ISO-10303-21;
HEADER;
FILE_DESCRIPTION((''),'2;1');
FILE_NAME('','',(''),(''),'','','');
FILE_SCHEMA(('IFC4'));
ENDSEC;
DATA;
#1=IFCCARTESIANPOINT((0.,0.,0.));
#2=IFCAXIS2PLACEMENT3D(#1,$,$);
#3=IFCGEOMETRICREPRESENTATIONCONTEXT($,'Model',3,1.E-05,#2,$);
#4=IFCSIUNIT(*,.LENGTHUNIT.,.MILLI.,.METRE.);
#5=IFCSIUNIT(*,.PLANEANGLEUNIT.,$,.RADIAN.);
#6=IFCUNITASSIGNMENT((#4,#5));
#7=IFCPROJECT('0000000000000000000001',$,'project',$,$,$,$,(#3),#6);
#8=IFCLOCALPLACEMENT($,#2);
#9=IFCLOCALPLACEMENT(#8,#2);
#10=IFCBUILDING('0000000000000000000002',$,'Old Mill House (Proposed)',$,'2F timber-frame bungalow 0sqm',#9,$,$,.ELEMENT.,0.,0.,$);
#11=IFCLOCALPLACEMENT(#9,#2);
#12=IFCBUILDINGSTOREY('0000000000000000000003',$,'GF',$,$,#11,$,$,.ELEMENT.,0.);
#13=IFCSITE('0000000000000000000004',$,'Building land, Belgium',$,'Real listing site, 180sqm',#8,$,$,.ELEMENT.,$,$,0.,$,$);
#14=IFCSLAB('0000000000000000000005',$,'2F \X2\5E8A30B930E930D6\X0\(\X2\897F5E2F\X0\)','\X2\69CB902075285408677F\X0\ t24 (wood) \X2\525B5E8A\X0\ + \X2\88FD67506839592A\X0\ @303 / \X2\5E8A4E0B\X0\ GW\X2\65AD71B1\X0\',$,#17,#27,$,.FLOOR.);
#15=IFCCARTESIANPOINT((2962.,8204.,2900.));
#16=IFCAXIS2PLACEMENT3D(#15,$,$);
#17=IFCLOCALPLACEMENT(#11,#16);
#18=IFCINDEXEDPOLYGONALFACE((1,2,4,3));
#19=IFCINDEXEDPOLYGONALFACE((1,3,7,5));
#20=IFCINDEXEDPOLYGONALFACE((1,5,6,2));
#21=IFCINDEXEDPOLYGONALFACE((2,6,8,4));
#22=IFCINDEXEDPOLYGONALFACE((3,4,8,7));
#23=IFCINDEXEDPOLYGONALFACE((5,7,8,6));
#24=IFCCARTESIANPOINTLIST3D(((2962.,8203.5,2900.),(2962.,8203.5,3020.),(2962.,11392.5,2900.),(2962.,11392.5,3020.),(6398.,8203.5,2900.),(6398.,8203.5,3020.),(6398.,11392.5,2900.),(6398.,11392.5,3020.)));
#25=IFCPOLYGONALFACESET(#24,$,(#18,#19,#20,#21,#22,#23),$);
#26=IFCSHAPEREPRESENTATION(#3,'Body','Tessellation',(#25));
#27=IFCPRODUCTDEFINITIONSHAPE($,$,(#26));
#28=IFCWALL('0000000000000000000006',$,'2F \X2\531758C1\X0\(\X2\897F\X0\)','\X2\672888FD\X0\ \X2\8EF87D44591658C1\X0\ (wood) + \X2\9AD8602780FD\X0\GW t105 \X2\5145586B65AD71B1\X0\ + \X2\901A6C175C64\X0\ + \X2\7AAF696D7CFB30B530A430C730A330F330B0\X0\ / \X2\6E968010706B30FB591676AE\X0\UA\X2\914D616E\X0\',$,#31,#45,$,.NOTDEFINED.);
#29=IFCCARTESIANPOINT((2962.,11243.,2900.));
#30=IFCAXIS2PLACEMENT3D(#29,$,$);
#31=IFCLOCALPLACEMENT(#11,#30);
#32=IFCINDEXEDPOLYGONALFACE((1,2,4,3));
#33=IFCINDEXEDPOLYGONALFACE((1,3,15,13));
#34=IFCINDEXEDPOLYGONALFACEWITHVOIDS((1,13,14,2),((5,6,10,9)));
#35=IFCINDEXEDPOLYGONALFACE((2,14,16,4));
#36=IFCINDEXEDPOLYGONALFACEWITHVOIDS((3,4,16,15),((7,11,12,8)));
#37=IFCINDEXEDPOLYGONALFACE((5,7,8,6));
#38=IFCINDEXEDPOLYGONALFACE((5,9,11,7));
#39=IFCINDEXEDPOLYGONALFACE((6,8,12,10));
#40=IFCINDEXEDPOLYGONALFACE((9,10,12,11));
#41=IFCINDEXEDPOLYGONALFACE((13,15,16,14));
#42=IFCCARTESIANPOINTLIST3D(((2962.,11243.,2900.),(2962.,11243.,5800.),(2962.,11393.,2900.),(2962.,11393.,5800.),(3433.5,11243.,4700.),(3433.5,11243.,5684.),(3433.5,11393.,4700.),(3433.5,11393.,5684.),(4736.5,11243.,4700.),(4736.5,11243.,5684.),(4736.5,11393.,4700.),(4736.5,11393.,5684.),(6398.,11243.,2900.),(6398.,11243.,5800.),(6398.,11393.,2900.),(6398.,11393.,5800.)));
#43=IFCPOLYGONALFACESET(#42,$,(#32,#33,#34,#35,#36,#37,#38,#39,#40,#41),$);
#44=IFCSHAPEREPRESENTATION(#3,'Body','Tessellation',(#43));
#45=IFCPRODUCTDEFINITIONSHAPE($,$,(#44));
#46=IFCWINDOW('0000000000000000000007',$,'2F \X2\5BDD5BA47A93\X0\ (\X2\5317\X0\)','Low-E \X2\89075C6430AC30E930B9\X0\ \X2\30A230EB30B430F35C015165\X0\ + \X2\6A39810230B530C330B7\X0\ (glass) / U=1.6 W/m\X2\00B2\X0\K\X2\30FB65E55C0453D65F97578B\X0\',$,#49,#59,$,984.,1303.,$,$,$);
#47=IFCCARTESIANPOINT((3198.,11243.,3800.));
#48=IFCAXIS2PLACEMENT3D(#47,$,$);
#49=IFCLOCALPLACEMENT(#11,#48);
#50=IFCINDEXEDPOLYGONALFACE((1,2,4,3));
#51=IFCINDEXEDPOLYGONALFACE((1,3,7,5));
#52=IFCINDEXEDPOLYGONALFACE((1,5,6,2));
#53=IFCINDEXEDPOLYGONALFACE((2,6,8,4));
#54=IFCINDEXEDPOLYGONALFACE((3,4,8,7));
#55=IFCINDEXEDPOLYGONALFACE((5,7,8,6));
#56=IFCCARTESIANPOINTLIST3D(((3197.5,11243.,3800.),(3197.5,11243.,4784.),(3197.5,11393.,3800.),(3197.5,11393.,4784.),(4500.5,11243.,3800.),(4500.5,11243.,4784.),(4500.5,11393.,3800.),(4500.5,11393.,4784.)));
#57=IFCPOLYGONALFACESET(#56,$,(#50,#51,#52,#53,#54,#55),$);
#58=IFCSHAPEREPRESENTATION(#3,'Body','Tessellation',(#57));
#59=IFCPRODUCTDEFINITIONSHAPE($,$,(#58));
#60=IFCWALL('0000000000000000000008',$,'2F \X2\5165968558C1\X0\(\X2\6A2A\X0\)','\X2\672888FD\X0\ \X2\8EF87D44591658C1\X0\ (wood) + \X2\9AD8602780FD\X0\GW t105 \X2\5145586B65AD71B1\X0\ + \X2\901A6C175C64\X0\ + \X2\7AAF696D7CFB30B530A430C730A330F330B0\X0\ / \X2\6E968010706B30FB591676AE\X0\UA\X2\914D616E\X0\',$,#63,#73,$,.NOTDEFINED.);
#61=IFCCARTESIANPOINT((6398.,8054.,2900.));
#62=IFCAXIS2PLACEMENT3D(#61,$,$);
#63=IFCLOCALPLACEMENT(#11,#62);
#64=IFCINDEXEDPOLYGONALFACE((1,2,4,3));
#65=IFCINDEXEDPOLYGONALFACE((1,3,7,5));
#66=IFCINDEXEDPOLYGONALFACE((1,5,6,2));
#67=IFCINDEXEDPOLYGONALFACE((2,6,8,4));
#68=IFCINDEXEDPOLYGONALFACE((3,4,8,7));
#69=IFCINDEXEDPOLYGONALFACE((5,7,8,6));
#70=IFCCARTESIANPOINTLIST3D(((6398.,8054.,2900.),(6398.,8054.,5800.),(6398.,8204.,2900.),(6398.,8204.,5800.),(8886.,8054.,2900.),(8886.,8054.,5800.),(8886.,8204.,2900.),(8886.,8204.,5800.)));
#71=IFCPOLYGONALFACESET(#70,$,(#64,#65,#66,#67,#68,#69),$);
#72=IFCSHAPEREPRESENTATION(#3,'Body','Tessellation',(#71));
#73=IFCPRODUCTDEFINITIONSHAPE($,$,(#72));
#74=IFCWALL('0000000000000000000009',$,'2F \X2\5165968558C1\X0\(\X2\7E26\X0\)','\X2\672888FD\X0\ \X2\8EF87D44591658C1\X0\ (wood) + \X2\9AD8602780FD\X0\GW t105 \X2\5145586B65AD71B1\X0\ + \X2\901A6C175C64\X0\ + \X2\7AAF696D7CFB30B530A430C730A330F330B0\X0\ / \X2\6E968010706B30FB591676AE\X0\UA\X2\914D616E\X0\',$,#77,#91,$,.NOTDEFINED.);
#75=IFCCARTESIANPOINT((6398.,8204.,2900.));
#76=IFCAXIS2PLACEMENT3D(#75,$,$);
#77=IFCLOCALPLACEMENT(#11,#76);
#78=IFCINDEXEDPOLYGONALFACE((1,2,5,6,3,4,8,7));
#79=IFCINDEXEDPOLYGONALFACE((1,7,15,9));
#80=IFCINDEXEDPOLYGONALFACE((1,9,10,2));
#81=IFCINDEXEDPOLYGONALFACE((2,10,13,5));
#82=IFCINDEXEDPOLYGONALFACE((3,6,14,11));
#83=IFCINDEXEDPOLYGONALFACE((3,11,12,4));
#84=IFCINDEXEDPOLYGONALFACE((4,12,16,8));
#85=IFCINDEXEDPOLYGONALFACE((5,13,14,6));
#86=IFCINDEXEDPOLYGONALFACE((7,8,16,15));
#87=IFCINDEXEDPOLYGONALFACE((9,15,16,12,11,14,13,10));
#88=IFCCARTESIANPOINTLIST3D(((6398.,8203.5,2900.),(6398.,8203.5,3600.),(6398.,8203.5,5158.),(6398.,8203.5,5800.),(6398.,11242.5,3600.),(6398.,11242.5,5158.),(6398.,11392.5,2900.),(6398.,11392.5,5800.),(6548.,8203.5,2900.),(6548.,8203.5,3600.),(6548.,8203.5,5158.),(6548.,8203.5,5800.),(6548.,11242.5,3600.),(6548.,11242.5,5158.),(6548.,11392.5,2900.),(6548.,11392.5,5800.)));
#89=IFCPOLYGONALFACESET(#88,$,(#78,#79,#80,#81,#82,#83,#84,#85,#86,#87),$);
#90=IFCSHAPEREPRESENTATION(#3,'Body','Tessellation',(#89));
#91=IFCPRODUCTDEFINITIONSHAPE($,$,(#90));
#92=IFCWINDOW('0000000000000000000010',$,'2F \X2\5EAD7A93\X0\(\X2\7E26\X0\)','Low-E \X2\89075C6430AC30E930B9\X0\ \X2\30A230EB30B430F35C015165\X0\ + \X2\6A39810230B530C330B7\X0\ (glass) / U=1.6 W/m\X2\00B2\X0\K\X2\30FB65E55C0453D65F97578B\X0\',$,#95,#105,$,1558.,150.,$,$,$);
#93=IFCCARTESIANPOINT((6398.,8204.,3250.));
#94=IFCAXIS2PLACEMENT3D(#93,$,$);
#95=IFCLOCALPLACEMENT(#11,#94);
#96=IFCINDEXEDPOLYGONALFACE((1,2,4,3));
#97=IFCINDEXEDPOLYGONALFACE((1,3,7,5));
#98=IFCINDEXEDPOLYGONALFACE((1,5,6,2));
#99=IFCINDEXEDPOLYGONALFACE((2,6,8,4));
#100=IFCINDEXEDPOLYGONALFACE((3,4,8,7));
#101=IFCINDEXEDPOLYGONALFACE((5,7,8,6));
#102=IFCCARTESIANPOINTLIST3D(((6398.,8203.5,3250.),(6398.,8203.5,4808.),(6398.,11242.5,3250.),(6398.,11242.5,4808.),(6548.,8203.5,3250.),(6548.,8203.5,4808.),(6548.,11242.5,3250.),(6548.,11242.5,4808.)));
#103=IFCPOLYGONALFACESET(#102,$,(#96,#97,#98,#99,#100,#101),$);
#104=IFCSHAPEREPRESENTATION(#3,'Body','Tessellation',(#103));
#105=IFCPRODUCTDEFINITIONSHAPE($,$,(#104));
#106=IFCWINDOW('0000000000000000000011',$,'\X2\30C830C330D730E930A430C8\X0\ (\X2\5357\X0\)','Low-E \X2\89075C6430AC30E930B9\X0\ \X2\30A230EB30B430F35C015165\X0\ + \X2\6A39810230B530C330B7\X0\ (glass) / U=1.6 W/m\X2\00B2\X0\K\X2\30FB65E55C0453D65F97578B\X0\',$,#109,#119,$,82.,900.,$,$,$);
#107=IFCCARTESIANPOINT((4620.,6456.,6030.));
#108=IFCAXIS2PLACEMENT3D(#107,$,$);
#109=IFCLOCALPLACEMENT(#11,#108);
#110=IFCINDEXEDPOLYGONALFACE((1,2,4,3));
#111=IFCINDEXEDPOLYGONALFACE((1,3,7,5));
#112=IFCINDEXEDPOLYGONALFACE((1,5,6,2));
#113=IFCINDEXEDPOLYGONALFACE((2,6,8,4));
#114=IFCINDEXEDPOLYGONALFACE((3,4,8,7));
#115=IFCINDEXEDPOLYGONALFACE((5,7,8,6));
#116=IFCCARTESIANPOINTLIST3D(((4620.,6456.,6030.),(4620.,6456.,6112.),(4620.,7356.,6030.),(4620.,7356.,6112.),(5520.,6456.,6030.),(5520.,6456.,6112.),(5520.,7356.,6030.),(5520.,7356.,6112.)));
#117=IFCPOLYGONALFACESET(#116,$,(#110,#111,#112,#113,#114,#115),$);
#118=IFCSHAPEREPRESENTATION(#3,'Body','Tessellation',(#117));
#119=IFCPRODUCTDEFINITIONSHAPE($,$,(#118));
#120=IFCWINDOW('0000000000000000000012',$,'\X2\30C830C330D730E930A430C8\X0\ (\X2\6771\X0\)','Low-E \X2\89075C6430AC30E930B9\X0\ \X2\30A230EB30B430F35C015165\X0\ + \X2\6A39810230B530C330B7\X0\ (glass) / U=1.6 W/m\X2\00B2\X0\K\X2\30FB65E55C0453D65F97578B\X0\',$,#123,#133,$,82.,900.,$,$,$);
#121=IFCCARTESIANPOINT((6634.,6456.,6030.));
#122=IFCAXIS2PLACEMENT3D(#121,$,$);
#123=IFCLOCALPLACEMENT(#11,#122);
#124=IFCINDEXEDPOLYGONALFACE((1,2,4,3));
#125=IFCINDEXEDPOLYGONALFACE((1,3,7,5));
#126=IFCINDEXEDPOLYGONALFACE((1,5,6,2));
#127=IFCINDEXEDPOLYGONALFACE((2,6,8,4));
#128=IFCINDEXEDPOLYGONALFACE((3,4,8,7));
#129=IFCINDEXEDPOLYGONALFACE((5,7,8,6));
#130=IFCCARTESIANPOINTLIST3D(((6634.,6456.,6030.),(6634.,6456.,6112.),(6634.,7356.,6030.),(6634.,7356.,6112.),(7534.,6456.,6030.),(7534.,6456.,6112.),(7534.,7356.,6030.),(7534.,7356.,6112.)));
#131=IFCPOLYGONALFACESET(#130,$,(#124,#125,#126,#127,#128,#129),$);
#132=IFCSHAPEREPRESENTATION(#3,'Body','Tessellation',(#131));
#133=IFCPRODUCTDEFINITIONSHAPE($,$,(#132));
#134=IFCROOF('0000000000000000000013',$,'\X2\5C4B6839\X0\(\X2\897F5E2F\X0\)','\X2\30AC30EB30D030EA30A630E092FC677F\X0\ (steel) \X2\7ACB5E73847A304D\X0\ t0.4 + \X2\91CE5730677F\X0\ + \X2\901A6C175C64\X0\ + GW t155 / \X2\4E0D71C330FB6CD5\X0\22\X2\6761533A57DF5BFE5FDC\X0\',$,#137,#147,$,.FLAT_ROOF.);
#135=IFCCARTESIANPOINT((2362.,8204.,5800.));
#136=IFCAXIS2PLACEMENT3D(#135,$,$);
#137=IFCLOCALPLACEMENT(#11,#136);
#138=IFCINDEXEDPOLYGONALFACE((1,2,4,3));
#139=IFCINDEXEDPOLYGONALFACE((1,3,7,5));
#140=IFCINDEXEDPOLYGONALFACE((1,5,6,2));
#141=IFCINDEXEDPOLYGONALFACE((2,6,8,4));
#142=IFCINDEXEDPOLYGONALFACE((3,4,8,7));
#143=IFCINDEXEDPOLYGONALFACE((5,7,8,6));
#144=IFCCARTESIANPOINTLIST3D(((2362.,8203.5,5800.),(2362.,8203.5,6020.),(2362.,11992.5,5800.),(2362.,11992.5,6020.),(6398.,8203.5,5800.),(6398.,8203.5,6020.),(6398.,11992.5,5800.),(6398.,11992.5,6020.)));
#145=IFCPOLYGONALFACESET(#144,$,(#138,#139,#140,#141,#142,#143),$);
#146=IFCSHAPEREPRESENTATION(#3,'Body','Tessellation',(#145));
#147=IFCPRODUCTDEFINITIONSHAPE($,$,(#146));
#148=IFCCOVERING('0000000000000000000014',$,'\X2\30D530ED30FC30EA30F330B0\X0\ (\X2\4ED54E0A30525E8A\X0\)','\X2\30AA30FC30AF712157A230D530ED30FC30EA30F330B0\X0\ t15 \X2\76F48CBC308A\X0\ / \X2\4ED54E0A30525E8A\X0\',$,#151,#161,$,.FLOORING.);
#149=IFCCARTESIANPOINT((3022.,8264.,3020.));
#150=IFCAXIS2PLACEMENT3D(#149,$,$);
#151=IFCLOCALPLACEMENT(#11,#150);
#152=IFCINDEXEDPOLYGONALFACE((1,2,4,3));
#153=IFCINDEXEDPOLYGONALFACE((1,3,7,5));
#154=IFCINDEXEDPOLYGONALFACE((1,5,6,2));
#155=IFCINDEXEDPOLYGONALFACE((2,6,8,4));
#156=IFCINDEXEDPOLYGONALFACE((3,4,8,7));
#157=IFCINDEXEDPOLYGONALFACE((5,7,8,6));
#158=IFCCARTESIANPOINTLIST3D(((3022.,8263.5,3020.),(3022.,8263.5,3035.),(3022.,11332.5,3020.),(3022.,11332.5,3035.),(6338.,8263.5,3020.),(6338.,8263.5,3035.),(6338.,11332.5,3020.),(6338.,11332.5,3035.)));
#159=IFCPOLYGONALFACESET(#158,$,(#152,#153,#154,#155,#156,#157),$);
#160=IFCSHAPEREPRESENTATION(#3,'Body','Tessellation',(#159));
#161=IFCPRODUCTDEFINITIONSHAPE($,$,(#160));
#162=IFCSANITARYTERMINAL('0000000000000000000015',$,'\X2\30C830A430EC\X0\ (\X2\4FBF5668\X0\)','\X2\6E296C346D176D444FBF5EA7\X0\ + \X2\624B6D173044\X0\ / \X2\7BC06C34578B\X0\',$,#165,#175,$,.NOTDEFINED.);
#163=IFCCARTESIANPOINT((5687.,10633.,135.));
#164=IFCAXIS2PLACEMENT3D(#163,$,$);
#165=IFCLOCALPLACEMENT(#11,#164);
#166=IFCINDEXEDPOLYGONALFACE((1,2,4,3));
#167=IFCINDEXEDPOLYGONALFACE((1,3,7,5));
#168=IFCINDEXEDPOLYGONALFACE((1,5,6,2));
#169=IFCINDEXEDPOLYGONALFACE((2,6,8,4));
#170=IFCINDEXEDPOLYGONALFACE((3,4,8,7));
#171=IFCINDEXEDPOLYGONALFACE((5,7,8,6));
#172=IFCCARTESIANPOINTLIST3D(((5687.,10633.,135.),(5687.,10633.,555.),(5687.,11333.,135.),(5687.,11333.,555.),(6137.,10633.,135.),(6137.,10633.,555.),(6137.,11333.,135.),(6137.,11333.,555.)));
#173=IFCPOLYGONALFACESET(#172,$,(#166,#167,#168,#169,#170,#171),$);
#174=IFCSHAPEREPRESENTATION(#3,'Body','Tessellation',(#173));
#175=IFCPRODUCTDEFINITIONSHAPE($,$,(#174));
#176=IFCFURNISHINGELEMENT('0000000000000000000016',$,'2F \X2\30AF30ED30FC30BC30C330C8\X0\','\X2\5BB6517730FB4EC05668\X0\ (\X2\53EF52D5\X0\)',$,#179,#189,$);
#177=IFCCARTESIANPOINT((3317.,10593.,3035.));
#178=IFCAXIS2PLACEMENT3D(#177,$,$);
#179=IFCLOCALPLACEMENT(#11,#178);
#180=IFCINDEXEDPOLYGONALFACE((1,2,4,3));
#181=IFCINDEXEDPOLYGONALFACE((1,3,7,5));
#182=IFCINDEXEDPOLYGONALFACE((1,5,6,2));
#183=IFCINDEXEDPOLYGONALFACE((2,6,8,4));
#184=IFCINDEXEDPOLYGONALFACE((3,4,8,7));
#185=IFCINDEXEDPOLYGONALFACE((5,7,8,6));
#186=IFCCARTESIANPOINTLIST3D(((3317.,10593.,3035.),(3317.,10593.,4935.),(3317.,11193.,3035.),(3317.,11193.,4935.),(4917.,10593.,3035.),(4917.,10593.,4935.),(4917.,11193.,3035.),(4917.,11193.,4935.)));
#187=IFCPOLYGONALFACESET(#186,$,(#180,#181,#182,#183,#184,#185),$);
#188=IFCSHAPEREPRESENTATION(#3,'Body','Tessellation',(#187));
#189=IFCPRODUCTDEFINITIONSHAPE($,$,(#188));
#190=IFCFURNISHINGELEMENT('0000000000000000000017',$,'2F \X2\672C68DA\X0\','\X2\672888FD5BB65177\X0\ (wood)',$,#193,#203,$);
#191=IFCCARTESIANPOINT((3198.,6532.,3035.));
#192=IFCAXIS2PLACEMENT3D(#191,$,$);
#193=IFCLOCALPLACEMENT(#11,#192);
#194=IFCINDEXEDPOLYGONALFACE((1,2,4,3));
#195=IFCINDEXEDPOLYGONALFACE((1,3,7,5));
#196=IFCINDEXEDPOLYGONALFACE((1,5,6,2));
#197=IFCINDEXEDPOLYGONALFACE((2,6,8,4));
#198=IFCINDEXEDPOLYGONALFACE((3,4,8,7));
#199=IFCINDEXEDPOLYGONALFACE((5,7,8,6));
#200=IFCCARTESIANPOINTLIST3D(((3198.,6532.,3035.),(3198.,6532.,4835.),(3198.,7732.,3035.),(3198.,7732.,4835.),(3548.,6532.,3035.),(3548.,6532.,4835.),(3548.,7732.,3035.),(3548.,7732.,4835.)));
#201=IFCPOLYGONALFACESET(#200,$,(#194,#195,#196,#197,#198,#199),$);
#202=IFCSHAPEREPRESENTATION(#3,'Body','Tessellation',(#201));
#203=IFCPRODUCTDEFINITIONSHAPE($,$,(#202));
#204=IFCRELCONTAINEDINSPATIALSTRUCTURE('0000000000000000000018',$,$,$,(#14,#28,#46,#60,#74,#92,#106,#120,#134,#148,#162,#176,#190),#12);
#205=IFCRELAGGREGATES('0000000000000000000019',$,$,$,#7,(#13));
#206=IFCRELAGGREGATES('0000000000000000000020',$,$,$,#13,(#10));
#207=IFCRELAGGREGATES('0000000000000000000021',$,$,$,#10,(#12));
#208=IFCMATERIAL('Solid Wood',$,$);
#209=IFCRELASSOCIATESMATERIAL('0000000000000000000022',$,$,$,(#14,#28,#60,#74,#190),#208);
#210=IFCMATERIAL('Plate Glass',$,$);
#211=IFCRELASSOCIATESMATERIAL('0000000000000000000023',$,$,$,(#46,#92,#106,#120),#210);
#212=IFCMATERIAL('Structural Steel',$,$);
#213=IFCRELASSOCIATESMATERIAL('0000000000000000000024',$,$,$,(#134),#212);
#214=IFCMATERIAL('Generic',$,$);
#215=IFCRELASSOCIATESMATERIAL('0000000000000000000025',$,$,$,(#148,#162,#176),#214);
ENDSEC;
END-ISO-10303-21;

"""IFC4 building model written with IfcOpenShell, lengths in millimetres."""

from ifc_helpers import new_model, si_unit, frame, frame_2d, origin, place, context, project, spatial, rectangle, extrude, material, element, fill, save


model = new_model("IFC4")

# Units and contexts
model_context = context("Model", 3, precision=1e-05, world=origin())
ifc_project = project(units=[si_unit("LENGTHUNIT", "METRE", prefix="MILLI"), si_unit("PLANEANGLEUNIT", "RADIAN")], contexts=[model_context])

# Site, building, storey
site_placement = place(None, origin())
site = spatial("IfcSite", under=ifc_project, at=site_placement, Name="Building land, Belgium", ObjectType="Real listing site, 180sqm", CompositionType="ELEMENT", RefElevation=0.0)
building_placement = place(site_placement, origin())
building = spatial("IfcBuilding", under=site, at=building_placement, Name="Old Mill House (Proposed)", ObjectType="2F timber-frame bungalow 0sqm", CompositionType="ELEMENT", ElevationOfRefHeight=0.0, ElevationOfTerrain=0.0)
storey_placement = place(building_placement, origin())
storey = spatial("IfcBuildingStorey", under=building, at=storey_placement, Name="GF", CompositionType="ELEMENT", Elevation=0.0)

# Slab
ifc_material_1 = material(Name="Solid Wood")
slab_placement = place(storey_placement, frame((2962.0, 8204.0, 2900.0)))
element("IfcSlab", 1, at=slab_placement, inside=storey, material=ifc_material_1, Name="2F 床スラブ(西帯)", Description="構造用合板 t24 (wood) 剛床 + 製材根太 @303 / 床下 GW断熱", PredefinedType="FLOOR", context=model_context, shape_type="SweptSolid", body=[
    extrude(rectangle(XDim=3436.0, YDim=3189.0, at=frame_2d((1718.0, 1594.0))), frame((2962.0, 8204.0, 2900.0)), (0.0, 0.0, 1.0), 120.0),
])

# Wall, opening, window
wall_1_placement = place(storey_placement, frame((2962.0, 11243.0, 2900.0)))
wall_1 = element("IfcWall", 2, at=wall_1_placement, inside=storey, material=ifc_material_1, Name="2F 北壁(西)", Description="木製 軸組外壁 (wood) + 高性能GW t105 充填断熱 + 通気層 + 窯業系サイディング / 準耐火・外皮UA配慮", PredefinedType="NOTDEFINED", context=model_context, shape_type="SweptSolid", body=[
    extrude(rectangle(XDim=3436.0, YDim=150.0, at=frame_2d((1718.0, 75.0))), frame((2962.0, 11243.0, 2900.0)), (0.0, 0.0, 1.0), 2900.0),
])
opening_1_placement = place(storey_placement, frame((3198.0, 11243.0, 3800.0)))
opening_1 = element("IfcOpeningElement", 3, at=opening_1_placement, cuts=wall_1, PredefinedType="NOTDEFINED", context=model_context, shape_type="SweptSolid", body=[
    extrude(rectangle(XDim=1303.0, YDim=150.0, at=frame_2d((651.0, 75.0))), frame((3198.0, 11243.0, 3800.0)), (0.0, 0.0, 1.0), 984.0),
])
ifc_material_2 = material(Name="Plate Glass")
window_1_placement = place(storey_placement, frame((3198.0, 11243.0, 3800.0)))
window_1 = element("IfcWindow", 4, at=window_1_placement, inside=storey, material=ifc_material_2, Name="2F 寝室窓 (北)", Description="Low-E 複層ガラス アルゴン封入 + 樹脂サッシ (glass) / U=1.6 W/m²K・日射取得型", OverallHeight=984.0, OverallWidth=1303.0, context=model_context, shape_type="SweptSolid", body=[
    extrude(rectangle(XDim=1303.0, YDim=150.0, at=frame_2d((651.0, 75.0))), frame((3198.0, 11243.0, 3800.0)), (0.0, 0.0, 1.0), 984.0),
])
fill(opening_1, window_1)

# Wall
wall_2_placement = place(storey_placement, frame((6398.0, 8054.0, 2900.0)))
element("IfcWall", 5, at=wall_2_placement, inside=storey, material=ifc_material_1, Name="2F 入隅壁(横)", Description="木製 軸組外壁 (wood) + 高性能GW t105 充填断熱 + 通気層 + 窯業系サイディング / 準耐火・外皮UA配慮", PredefinedType="NOTDEFINED", context=model_context, shape_type="SweptSolid", body=[
    extrude(rectangle(XDim=2488.0, YDim=150.0, at=frame_2d((1244.0, 75.0))), frame((6398.0, 8054.0, 2900.0)), (0.0, 0.0, 1.0), 2900.0),
])

# Wall, opening, window
wall_3_placement = place(storey_placement, frame((6398.0, 8204.0, 2900.0)))
wall_3 = element("IfcWall", 6, at=wall_3_placement, inside=storey, material=ifc_material_1, Name="2F 入隅壁(縦)", Description="木製 軸組外壁 (wood) + 高性能GW t105 充填断熱 + 通気層 + 窯業系サイディング / 準耐火・外皮UA配慮", PredefinedType="NOTDEFINED", context=model_context, shape_type="SweptSolid", body=[
    extrude(rectangle(XDim=150.0, YDim=3189.0, at=frame_2d((75.0, 1594.0))), frame((6398.0, 8204.0, 2900.0)), (0.0, 0.0, 1.0), 2900.0),
])
opening_2_placement = place(storey_placement, frame((6398.0, 8204.0, 3250.0)))
opening_2 = element("IfcOpeningElement", 7, at=opening_2_placement, cuts=wall_3, PredefinedType="NOTDEFINED", context=model_context, shape_type="SweptSolid", body=[
    extrude(rectangle(XDim=150.0, YDim=3039.0, at=frame_2d((75.0, 1519.0))), frame((6398.0, 8204.0, 3250.0)), (0.0, 0.0, 1.0), 1558.0),
])
window_2_placement = place(storey_placement, frame((6398.0, 8204.0, 3250.0)))
window_2 = element("IfcWindow", 8, at=window_2_placement, inside=storey, material=ifc_material_2, Name="2F 庭窓(縦)", Description="Low-E 複層ガラス アルゴン封入 + 樹脂サッシ (glass) / U=1.6 W/m²K・日射取得型", OverallHeight=1558.0, OverallWidth=150.0, context=model_context, shape_type="SweptSolid", body=[
    extrude(rectangle(XDim=150.0, YDim=3039.0, at=frame_2d((75.0, 1519.0))), frame((6398.0, 8204.0, 3250.0)), (0.0, 0.0, 1.0), 1558.0),
])
fill(opening_2, window_2)

# Windows
window_3_placement = place(storey_placement, frame((4620.0, 6456.0, 6030.0)))
element("IfcWindow", 9, at=window_3_placement, inside=storey, material=ifc_material_2, Name="トップライト (南)", Description="Low-E 複層ガラス アルゴン封入 + 樹脂サッシ (glass) / U=1.6 W/m²K・日射取得型", OverallHeight=82.0, OverallWidth=900.0, context=model_context, shape_type="SweptSolid", body=[
    extrude(rectangle(XDim=900.0, YDim=900.0, at=frame_2d((450.0, 450.0))), frame((4620.0, 6456.0, 6030.0)), (0.0, 0.0, 1.0), 82.0),
])
window_4_placement = place(storey_placement, frame((6634.0, 6456.0, 6030.0)))
element("IfcWindow", 10, at=window_4_placement, inside=storey, material=ifc_material_2, Name="トップライト (東)", Description="Low-E 複層ガラス アルゴン封入 + 樹脂サッシ (glass) / U=1.6 W/m²K・日射取得型", OverallHeight=82.0, OverallWidth=900.0, context=model_context, shape_type="SweptSolid", body=[
    extrude(rectangle(XDim=900.0, YDim=900.0, at=frame_2d((450.0, 450.0))), frame((6634.0, 6456.0, 6030.0)), (0.0, 0.0, 1.0), 82.0),
])

# Roof
ifc_material_3 = material(Name="Structural Steel")
for number, where, name in (
    (11, (2362.0, 8204.0, 5800.0), "屋根(西帯)"),
):
    element("IfcRoof", number, at=place(storey_placement, frame(where)), inside=storey, material=ifc_material_3, Name=name, Description="ガルバリウム鋼板 (steel) 立平葺き t0.4 + 野地板 + 通気層 + GW t155 / 不燃・法22条区域対応", PredefinedType="FLAT_ROOF", context=model_context, shape_type="SweptSolid", body=[
        extrude(rectangle(XDim=4036.0, YDim=3789.0, at=frame_2d((2018.0, 1894.0))), frame((2362.0, 8204.0, 5800.0)), (0.0, 0.0, 1.0), 220.0),
    ])

# Covering
ifc_material_4 = material(Name="Generic")
covering_placement = place(storey_placement, frame((3022.0, 8264.0, 3020.0)))
element("IfcCovering", 12, at=covering_placement, inside=storey, material=ifc_material_4, Name="フローリング (仕上げ床)", Description="オーク無垢フローリング t15 直貼り / 仕上げ床", PredefinedType="FLOORING", context=model_context, shape_type="SweptSolid", body=[
    extrude(rectangle(XDim=3316.0, YDim=3069.0, at=frame_2d((1658.0, 1534.0))), frame((3022.0, 8264.0, 3020.0)), (0.0, 0.0, 1.0), 15.0),
])

# Sanitary terminal
sanitary_terminal_placement = place(storey_placement, frame((5687.0, 10633.0, 135.0)))
element("IfcSanitaryTerminal", 13, at=sanitary_terminal_placement, inside=storey, material=ifc_material_4, Name="トイレ (便器)", Description="温水洗浄便座 + 手洗い / 節水型", PredefinedType="NOTDEFINED", context=model_context, shape_type="SweptSolid", body=[
    extrude(rectangle(XDim=450.0, YDim=700.0, at=frame_2d((225.0, 350.0))), frame((5687.0, 10633.0, 135.0)), (0.0, 0.0, 1.0), 420.0),
])

# Furnishing elements
furnishing_1_placement = place(storey_placement, frame((3317.0, 10593.0, 3035.0)))
element("IfcFurnishingElement", 14, at=furnishing_1_placement, inside=storey, material=ifc_material_4, Name="2F クローゼット", Description="家具・什器 (可動)", context=model_context, shape_type="SweptSolid", body=[
    extrude(rectangle(XDim=1600.0, YDim=600.0, at=frame_2d((800.0, 300.0))), frame((3317.0, 10593.0, 3035.0)), (0.0, 0.0, 1.0), 1900.0),
])
furnishing_2_placement = place(storey_placement, frame((3198.0, 6532.0, 3035.0)))
element("IfcFurnishingElement", 15, at=furnishing_2_placement, inside=storey, material=ifc_material_1, Name="2F 本棚", Description="木製家具 (wood)", context=model_context, shape_type="SweptSolid", body=[
    extrude(rectangle(XDim=350.0, YDim=1200.0, at=frame_2d((175.0, 600.0))), frame((3198.0, 6532.0, 3035.0)), (0.0, 0.0, 1.0), 1800.0),
])

save(model, "model.ifc")
